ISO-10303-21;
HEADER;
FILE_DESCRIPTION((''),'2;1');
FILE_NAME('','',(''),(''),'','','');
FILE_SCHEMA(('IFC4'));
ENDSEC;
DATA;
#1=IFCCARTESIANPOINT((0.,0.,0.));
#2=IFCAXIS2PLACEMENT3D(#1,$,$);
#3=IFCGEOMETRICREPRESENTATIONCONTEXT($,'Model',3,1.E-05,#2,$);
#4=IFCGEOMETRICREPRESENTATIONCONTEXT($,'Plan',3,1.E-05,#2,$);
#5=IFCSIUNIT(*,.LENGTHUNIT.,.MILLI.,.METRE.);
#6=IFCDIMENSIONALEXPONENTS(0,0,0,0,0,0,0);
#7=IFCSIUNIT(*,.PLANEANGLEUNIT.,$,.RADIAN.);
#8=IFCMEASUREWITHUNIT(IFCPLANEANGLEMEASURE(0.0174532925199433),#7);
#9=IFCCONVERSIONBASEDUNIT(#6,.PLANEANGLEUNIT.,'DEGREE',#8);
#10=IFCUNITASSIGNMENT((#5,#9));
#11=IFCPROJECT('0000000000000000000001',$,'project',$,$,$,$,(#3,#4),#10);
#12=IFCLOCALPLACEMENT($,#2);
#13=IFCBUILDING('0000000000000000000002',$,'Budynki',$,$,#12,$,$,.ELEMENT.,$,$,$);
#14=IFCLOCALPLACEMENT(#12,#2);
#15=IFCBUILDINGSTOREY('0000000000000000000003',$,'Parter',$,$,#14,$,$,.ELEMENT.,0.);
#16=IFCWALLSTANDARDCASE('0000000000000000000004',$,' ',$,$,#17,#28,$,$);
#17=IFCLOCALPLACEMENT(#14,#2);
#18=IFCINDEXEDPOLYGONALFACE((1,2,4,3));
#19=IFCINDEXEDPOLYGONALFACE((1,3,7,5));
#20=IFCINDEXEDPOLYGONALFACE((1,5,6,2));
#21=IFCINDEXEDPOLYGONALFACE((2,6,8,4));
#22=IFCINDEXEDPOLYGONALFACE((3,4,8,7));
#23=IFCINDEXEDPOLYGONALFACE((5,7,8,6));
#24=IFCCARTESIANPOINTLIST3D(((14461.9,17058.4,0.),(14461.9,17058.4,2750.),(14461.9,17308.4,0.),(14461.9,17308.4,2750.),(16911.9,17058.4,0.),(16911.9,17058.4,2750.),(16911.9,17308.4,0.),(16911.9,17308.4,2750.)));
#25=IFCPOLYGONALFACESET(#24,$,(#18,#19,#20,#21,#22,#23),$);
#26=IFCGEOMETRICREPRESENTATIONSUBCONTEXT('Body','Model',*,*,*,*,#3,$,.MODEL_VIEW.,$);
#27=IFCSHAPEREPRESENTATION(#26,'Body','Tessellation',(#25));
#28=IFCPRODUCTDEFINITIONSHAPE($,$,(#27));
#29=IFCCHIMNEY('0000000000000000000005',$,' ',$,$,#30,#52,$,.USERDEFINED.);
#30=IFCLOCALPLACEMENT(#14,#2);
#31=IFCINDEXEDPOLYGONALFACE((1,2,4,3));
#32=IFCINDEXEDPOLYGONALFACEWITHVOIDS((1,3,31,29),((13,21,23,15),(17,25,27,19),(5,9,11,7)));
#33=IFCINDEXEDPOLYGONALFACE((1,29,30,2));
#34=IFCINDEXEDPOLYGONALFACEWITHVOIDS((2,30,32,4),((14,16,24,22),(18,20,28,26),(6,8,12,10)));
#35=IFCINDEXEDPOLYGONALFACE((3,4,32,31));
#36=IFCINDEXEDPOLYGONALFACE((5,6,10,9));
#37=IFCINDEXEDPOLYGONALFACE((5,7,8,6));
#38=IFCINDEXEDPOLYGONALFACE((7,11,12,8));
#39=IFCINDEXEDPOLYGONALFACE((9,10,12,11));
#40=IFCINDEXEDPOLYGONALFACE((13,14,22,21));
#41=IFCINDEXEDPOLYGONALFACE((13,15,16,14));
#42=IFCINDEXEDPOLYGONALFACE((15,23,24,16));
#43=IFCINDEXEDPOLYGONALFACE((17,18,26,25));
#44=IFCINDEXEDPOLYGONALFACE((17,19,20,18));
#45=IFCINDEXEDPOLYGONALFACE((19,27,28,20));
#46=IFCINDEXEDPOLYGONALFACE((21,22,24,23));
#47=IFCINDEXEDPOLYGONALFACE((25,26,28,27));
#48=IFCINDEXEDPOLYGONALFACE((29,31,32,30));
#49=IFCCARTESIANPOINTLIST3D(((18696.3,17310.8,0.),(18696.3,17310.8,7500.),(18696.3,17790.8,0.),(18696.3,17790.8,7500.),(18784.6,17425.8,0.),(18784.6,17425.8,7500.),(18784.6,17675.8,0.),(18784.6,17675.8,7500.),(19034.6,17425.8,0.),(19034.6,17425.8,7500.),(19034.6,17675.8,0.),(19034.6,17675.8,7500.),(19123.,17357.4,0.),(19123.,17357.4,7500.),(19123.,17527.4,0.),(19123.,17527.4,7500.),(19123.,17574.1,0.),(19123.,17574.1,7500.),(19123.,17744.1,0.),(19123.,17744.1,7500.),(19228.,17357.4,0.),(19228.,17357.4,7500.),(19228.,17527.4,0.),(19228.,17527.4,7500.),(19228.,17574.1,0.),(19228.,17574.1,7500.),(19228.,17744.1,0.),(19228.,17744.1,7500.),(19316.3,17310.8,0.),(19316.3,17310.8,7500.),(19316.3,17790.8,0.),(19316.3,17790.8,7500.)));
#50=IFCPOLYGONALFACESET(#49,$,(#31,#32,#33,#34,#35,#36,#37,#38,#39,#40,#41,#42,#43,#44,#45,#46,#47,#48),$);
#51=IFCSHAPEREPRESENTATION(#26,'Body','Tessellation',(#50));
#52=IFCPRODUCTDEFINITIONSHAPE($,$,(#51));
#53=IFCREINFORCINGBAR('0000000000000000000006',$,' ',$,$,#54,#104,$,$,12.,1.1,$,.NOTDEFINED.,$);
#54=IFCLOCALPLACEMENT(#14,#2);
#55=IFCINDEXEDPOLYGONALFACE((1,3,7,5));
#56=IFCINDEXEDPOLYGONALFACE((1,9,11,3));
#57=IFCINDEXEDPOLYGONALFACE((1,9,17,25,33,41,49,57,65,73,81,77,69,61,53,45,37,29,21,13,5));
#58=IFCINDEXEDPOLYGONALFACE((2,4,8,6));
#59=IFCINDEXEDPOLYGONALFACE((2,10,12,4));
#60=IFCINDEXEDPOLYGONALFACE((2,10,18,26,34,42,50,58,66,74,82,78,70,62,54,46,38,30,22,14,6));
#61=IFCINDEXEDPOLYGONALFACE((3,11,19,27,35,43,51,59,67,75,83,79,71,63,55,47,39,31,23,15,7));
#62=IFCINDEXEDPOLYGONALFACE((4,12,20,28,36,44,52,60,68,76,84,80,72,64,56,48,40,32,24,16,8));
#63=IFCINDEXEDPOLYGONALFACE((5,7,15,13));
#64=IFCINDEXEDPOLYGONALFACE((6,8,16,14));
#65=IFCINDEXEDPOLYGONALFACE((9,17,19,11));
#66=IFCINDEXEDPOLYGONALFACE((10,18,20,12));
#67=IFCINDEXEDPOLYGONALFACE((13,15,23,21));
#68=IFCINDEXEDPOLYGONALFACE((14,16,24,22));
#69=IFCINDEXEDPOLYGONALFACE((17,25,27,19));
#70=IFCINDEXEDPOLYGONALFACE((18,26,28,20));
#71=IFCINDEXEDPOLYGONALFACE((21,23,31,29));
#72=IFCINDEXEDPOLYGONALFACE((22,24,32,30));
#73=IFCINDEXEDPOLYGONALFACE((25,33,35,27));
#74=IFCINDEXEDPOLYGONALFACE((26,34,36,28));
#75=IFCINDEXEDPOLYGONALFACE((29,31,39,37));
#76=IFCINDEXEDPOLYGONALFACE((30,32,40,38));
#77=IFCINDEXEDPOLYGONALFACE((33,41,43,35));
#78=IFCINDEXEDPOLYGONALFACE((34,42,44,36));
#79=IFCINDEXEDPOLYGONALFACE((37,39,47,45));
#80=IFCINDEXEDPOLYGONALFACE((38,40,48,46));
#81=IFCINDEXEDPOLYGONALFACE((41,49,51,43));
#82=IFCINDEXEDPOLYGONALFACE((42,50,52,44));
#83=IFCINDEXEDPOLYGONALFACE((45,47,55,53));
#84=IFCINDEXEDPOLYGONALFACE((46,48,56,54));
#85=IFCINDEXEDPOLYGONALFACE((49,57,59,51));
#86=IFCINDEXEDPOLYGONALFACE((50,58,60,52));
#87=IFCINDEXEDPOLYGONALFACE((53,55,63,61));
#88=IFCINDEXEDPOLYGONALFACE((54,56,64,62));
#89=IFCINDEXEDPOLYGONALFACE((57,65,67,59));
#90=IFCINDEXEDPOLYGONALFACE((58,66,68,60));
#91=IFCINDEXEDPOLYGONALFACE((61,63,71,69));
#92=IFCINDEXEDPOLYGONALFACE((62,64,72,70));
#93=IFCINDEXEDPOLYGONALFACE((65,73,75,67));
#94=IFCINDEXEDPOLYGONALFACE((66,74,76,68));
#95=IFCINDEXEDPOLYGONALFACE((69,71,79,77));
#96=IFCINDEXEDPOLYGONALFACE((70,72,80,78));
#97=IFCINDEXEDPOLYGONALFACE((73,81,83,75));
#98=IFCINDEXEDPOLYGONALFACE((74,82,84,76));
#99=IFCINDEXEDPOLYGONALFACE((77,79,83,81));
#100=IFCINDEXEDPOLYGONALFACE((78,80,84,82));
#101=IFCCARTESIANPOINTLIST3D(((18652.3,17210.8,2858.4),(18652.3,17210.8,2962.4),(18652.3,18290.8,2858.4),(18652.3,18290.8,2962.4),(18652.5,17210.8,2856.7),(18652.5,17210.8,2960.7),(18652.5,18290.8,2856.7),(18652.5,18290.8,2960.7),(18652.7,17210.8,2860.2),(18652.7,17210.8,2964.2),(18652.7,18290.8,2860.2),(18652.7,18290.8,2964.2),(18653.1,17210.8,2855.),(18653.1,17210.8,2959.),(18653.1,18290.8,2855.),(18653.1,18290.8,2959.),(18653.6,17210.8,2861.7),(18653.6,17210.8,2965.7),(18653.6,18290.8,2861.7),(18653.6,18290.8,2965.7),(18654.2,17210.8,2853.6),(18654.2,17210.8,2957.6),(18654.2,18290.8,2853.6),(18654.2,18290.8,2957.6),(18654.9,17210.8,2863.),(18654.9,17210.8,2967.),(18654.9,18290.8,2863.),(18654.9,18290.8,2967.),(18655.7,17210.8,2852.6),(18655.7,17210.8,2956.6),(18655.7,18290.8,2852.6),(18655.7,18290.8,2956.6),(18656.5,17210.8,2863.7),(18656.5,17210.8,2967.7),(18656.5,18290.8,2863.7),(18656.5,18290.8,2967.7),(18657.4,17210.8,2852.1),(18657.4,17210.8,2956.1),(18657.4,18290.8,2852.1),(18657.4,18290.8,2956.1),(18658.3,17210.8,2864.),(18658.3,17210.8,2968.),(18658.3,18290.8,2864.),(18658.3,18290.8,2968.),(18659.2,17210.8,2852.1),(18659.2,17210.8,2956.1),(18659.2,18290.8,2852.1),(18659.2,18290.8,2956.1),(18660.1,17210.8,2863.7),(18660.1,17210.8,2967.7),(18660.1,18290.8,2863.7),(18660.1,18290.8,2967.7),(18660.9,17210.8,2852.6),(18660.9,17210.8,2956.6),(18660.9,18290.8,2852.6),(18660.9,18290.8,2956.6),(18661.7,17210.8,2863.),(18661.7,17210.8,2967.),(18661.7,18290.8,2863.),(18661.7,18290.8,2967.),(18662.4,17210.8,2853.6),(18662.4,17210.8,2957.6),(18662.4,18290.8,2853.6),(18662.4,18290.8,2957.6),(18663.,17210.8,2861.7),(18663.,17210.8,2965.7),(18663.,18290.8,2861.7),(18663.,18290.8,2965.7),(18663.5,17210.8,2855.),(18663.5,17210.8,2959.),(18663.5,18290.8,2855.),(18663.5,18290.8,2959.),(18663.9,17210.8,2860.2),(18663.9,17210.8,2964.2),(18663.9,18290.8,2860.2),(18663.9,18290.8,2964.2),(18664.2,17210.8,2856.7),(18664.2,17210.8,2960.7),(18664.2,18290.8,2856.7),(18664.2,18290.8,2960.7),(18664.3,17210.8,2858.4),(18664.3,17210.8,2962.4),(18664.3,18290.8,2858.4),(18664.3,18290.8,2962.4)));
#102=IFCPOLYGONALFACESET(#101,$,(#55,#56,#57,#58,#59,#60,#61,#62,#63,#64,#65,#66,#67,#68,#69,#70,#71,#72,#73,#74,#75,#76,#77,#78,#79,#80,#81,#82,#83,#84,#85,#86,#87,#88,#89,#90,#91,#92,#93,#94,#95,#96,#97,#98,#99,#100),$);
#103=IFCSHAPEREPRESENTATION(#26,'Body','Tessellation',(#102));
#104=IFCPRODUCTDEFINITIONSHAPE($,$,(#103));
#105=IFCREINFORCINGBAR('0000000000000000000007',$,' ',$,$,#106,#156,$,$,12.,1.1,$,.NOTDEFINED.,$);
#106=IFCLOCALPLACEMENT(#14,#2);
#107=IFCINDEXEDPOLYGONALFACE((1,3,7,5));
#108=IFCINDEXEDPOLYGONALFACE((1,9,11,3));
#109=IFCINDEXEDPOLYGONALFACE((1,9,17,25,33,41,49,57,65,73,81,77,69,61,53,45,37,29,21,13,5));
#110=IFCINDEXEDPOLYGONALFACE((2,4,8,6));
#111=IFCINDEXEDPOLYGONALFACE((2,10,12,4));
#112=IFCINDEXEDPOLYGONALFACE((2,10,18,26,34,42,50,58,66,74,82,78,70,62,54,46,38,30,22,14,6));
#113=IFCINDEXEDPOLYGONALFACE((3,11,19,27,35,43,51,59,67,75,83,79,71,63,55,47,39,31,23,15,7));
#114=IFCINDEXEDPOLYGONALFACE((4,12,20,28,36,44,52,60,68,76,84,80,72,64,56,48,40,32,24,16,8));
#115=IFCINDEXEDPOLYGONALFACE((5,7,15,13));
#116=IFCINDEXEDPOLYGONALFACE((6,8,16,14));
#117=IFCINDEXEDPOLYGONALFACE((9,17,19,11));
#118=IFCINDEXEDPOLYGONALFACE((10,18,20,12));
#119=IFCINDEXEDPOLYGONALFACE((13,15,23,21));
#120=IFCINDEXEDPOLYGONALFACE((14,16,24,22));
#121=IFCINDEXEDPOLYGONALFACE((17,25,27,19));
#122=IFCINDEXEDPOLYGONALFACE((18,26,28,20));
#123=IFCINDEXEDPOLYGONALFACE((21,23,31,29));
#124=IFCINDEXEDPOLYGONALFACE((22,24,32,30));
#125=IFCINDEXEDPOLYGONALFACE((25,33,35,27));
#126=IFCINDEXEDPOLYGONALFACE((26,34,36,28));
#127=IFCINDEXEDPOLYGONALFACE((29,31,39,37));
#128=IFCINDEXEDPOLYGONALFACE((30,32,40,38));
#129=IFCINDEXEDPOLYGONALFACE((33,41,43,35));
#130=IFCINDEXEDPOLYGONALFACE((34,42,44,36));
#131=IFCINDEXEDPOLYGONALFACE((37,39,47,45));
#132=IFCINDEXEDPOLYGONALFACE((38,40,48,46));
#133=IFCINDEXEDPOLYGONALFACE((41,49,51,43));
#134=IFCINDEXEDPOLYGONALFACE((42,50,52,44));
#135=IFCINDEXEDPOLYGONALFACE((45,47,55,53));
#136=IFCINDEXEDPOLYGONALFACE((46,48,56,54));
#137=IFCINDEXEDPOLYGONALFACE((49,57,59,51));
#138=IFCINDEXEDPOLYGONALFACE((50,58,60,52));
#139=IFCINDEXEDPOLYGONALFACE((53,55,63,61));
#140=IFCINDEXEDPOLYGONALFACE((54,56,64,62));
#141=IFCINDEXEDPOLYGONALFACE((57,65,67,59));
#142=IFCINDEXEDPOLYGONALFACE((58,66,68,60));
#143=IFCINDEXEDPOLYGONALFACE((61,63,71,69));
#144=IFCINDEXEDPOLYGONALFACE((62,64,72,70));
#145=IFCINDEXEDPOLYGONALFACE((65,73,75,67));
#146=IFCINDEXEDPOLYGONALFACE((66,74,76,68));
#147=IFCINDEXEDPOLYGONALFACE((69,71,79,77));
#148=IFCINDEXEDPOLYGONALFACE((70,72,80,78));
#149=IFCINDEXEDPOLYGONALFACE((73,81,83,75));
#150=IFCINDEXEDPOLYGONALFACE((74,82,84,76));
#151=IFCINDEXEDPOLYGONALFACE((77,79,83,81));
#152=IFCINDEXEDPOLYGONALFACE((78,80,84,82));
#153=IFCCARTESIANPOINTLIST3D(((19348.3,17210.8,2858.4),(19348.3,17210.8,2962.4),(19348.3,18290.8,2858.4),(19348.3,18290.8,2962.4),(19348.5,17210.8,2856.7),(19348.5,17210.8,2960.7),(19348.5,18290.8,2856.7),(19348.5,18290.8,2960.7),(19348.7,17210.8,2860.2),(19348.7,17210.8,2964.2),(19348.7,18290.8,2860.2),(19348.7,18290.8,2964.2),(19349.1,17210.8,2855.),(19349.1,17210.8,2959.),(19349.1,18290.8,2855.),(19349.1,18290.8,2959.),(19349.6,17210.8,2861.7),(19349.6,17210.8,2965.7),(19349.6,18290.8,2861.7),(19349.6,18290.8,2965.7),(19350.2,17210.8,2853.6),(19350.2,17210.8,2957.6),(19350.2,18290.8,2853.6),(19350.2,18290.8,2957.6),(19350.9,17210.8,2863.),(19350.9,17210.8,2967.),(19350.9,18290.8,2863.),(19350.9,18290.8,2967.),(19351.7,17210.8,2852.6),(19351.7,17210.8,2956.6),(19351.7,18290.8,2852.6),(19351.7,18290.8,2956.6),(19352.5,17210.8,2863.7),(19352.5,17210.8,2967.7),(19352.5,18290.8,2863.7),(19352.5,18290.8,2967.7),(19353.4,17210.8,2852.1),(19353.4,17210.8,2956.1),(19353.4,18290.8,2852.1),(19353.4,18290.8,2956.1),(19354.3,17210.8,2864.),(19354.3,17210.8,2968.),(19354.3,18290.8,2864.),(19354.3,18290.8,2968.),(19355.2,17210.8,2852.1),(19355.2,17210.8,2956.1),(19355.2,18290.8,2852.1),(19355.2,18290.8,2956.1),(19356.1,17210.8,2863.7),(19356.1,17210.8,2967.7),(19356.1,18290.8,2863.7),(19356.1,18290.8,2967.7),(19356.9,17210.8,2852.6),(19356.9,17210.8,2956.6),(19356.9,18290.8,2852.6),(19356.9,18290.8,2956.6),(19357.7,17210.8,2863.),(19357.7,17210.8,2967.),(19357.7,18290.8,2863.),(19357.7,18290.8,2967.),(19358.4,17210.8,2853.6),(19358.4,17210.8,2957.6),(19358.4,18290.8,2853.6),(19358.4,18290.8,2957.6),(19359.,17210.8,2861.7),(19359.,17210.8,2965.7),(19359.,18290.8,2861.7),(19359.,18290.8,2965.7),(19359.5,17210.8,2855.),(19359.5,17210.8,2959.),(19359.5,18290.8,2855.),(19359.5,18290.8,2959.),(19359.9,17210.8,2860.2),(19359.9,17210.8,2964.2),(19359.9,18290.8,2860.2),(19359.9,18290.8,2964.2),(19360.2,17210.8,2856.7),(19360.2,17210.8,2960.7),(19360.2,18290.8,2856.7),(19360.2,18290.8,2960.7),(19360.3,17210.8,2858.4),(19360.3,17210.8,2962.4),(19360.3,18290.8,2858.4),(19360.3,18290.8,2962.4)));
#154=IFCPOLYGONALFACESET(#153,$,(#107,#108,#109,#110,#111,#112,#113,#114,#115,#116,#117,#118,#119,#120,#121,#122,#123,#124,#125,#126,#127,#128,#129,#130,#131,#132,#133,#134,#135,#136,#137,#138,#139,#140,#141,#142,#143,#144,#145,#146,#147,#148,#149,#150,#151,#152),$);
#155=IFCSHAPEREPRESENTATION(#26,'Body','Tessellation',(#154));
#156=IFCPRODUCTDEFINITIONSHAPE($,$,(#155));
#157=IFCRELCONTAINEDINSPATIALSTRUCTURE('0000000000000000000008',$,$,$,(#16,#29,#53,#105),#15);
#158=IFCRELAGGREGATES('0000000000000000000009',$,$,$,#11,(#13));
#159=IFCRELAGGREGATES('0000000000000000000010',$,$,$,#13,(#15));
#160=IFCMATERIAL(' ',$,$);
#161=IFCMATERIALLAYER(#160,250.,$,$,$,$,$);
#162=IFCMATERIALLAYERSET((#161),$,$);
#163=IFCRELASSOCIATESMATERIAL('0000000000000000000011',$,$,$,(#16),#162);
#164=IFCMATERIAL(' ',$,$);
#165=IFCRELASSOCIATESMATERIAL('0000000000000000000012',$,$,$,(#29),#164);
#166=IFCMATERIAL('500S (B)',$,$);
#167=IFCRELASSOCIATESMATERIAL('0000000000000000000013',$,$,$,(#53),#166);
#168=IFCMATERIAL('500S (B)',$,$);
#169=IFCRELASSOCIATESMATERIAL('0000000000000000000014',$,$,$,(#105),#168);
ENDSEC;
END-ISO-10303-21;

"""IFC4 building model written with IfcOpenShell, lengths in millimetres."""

from ifc_helpers import new_model, entity, si_unit, converted_unit, frame, frame_2d, origin, origin_with_axes, place, context, subcontext, project, spatial, polyline, rectangle, outline, extrude, source, transform, mapped, material, layer, layer_set, layer_usage, element, save


model = new_model("IFC4")

# Units and contexts
model_context = context("Model", 3, precision=1e-05, world=origin())
plan_context = context("Plan", 3, precision=1e-05, world=origin())
body_context = subcontext(model_context, "Body", "Model", "MODEL_VIEW")
ifc_project = project(units=[si_unit("LENGTHUNIT", "METRE", prefix="MILLI"), converted_unit("PLANEANGLEUNIT", "DEGREE", entity("IfcPlaneAngleMeasure", 0.0174532925199433), si_unit("PLANEANGLEUNIT", "RADIAN"), dimensions=[0, 0, 0, 0, 0, 0, 0])], contexts=[model_context, plan_context])

# Building, storey
building_placement = place(None, origin())
building = spatial("IfcBuilding", under=ifc_project, at=building_placement, Name="Budynki", CompositionType="ELEMENT")
storey_placement = place(building_placement, origin())
storey = spatial("IfcBuildingStorey", under=building, at=storey_placement, Name="Parter", CompositionType="ELEMENT", Elevation=0.0)

# Wall
ifc_material_1 = material(Name=" ")
ifc_layer_1 = layer(ifc_material_1, 250.0)
ifc_layer_set_1 = layer_set([ifc_layer_1])
ifc_layer_usage_1 = layer_usage(ifc_layer_set_1, "AXIS2", "POSITIVE", 0.0)
wall_1_placement = place(storey_placement, frame((16911.9, 17308.4, 0.0), z_axis=(0.0, 0.0, 1.0), x_axis=(-1.0, 0.0, 0.0)))
element("IfcWallStandardCase", 1, at=wall_1_placement, inside=storey, material=ifc_layer_usage_1, Name=" ", context=body_context, shape_type="SweptSolid", body=[
    extrude(rectangle(XDim=2450.0, YDim=250.0, at=frame_2d((1225.0, 125.0), x_axis=(1.0, 0.0))), origin_with_axes(), (0.0, 0.0, 1.0), 2750.0),
])

# Chimney
ifc_material_2 = material(Name=" ")
chimney_placement = place(storey_placement, frame((18696.3, 17310.8, 0.0)))
element("IfcChimney", 2, at=chimney_placement, inside=storey, material=ifc_material_2, Name=" ", PredefinedType="USERDEFINED", context=body_context, shape_type="SweptSolid", body=[
    extrude(outline(polyline([(0.0, 0.0), (620.0, 0.0), (620.0, 480.0), (0.0, 480.0), (0.0, 0.0)]), holes=[polyline([(88.3, 115.0), (88.3, 365.0), (338.3, 365.0), (338.3, 115.0), (88.3, 115.0)]), polyline([(426.7, 46.7), (426.7, 216.7), (531.7, 216.7), (531.7, 46.7), (426.7, 46.7)]), polyline([(426.7, 263.3), (426.7, 433.3), (531.7, 433.3), (531.7, 263.3), (426.7, 263.3)])]), origin_with_axes(), (0.0, 0.0, 1.0), 7500.0),
])

# Reinforcing bars
ifc_material_3 = material(Name="500S (B)")
shared_shape_1 = source(origin_with_axes(), body_context, "Body", "AdvancedSweptSolid", [
    entity("IfcSweptDiskSolid", entity("IfcPolyline", [entity("IfcCartesianPoint", [0.0, 0.0, 0.0]), entity("IfcCartesianPoint", [0.0, 1080.0, 0.0])]), 6.0, None, 0.0, 1.0),
])
reinforcing_bar_1_placement = place(storey_placement, frame((18658.3, 17210.8, 2858.0)))
element("IfcReinforcingBar", 3, at=reinforcing_bar_1_placement, inside=storey, material=ifc_material_3, Name=" ", CrossSectionArea=1.1, NominalDiameter=12.0, PredefinedType="NOTDEFINED", context=body_context, shape_type="MappedRepresentation", body=[
    mapped(shared_shape_1, transform((0.0, 0.0, 0.0), y_axis=(0.0, 1.0, 0.0), scale=1.0)),
    mapped(shared_shape_1, transform((0.0, 0.0, 104.0), y_axis=(0.0, 1.0, 0.0), scale=1.0)),
])
ifc_material_4 = material(Name="500S (B)")
shared_shape_2 = source(origin_with_axes(), body_context, "Body", "AdvancedSweptSolid", [
    entity("IfcSweptDiskSolid", entity("IfcPolyline", [entity("IfcCartesianPoint", [0.0, 0.0, 0.0]), entity("IfcCartesianPoint", [0.0, 1080.0, 0.0])]), 6.0, None, 0.0, 1.0),
])
reinforcing_bar_2_placement = place(storey_placement, frame((19354.3, 17210.8, 2858.0)))
element("IfcReinforcingBar", 4, at=reinforcing_bar_2_placement, inside=storey, material=ifc_material_4, Name=" ", CrossSectionArea=1.1, NominalDiameter=12.0, PredefinedType="NOTDEFINED", context=body_context, shape_type="MappedRepresentation", body=[
    mapped(shared_shape_2, transform((0.0, 0.0, 0.0), y_axis=(0.0, 1.0, 0.0), scale=1.0)),
    mapped(shared_shape_2, transform((0.0, 0.0, 104.0), y_axis=(0.0, 1.0, 0.0), scale=1.0)),
])

save(model, "model.ifc")
